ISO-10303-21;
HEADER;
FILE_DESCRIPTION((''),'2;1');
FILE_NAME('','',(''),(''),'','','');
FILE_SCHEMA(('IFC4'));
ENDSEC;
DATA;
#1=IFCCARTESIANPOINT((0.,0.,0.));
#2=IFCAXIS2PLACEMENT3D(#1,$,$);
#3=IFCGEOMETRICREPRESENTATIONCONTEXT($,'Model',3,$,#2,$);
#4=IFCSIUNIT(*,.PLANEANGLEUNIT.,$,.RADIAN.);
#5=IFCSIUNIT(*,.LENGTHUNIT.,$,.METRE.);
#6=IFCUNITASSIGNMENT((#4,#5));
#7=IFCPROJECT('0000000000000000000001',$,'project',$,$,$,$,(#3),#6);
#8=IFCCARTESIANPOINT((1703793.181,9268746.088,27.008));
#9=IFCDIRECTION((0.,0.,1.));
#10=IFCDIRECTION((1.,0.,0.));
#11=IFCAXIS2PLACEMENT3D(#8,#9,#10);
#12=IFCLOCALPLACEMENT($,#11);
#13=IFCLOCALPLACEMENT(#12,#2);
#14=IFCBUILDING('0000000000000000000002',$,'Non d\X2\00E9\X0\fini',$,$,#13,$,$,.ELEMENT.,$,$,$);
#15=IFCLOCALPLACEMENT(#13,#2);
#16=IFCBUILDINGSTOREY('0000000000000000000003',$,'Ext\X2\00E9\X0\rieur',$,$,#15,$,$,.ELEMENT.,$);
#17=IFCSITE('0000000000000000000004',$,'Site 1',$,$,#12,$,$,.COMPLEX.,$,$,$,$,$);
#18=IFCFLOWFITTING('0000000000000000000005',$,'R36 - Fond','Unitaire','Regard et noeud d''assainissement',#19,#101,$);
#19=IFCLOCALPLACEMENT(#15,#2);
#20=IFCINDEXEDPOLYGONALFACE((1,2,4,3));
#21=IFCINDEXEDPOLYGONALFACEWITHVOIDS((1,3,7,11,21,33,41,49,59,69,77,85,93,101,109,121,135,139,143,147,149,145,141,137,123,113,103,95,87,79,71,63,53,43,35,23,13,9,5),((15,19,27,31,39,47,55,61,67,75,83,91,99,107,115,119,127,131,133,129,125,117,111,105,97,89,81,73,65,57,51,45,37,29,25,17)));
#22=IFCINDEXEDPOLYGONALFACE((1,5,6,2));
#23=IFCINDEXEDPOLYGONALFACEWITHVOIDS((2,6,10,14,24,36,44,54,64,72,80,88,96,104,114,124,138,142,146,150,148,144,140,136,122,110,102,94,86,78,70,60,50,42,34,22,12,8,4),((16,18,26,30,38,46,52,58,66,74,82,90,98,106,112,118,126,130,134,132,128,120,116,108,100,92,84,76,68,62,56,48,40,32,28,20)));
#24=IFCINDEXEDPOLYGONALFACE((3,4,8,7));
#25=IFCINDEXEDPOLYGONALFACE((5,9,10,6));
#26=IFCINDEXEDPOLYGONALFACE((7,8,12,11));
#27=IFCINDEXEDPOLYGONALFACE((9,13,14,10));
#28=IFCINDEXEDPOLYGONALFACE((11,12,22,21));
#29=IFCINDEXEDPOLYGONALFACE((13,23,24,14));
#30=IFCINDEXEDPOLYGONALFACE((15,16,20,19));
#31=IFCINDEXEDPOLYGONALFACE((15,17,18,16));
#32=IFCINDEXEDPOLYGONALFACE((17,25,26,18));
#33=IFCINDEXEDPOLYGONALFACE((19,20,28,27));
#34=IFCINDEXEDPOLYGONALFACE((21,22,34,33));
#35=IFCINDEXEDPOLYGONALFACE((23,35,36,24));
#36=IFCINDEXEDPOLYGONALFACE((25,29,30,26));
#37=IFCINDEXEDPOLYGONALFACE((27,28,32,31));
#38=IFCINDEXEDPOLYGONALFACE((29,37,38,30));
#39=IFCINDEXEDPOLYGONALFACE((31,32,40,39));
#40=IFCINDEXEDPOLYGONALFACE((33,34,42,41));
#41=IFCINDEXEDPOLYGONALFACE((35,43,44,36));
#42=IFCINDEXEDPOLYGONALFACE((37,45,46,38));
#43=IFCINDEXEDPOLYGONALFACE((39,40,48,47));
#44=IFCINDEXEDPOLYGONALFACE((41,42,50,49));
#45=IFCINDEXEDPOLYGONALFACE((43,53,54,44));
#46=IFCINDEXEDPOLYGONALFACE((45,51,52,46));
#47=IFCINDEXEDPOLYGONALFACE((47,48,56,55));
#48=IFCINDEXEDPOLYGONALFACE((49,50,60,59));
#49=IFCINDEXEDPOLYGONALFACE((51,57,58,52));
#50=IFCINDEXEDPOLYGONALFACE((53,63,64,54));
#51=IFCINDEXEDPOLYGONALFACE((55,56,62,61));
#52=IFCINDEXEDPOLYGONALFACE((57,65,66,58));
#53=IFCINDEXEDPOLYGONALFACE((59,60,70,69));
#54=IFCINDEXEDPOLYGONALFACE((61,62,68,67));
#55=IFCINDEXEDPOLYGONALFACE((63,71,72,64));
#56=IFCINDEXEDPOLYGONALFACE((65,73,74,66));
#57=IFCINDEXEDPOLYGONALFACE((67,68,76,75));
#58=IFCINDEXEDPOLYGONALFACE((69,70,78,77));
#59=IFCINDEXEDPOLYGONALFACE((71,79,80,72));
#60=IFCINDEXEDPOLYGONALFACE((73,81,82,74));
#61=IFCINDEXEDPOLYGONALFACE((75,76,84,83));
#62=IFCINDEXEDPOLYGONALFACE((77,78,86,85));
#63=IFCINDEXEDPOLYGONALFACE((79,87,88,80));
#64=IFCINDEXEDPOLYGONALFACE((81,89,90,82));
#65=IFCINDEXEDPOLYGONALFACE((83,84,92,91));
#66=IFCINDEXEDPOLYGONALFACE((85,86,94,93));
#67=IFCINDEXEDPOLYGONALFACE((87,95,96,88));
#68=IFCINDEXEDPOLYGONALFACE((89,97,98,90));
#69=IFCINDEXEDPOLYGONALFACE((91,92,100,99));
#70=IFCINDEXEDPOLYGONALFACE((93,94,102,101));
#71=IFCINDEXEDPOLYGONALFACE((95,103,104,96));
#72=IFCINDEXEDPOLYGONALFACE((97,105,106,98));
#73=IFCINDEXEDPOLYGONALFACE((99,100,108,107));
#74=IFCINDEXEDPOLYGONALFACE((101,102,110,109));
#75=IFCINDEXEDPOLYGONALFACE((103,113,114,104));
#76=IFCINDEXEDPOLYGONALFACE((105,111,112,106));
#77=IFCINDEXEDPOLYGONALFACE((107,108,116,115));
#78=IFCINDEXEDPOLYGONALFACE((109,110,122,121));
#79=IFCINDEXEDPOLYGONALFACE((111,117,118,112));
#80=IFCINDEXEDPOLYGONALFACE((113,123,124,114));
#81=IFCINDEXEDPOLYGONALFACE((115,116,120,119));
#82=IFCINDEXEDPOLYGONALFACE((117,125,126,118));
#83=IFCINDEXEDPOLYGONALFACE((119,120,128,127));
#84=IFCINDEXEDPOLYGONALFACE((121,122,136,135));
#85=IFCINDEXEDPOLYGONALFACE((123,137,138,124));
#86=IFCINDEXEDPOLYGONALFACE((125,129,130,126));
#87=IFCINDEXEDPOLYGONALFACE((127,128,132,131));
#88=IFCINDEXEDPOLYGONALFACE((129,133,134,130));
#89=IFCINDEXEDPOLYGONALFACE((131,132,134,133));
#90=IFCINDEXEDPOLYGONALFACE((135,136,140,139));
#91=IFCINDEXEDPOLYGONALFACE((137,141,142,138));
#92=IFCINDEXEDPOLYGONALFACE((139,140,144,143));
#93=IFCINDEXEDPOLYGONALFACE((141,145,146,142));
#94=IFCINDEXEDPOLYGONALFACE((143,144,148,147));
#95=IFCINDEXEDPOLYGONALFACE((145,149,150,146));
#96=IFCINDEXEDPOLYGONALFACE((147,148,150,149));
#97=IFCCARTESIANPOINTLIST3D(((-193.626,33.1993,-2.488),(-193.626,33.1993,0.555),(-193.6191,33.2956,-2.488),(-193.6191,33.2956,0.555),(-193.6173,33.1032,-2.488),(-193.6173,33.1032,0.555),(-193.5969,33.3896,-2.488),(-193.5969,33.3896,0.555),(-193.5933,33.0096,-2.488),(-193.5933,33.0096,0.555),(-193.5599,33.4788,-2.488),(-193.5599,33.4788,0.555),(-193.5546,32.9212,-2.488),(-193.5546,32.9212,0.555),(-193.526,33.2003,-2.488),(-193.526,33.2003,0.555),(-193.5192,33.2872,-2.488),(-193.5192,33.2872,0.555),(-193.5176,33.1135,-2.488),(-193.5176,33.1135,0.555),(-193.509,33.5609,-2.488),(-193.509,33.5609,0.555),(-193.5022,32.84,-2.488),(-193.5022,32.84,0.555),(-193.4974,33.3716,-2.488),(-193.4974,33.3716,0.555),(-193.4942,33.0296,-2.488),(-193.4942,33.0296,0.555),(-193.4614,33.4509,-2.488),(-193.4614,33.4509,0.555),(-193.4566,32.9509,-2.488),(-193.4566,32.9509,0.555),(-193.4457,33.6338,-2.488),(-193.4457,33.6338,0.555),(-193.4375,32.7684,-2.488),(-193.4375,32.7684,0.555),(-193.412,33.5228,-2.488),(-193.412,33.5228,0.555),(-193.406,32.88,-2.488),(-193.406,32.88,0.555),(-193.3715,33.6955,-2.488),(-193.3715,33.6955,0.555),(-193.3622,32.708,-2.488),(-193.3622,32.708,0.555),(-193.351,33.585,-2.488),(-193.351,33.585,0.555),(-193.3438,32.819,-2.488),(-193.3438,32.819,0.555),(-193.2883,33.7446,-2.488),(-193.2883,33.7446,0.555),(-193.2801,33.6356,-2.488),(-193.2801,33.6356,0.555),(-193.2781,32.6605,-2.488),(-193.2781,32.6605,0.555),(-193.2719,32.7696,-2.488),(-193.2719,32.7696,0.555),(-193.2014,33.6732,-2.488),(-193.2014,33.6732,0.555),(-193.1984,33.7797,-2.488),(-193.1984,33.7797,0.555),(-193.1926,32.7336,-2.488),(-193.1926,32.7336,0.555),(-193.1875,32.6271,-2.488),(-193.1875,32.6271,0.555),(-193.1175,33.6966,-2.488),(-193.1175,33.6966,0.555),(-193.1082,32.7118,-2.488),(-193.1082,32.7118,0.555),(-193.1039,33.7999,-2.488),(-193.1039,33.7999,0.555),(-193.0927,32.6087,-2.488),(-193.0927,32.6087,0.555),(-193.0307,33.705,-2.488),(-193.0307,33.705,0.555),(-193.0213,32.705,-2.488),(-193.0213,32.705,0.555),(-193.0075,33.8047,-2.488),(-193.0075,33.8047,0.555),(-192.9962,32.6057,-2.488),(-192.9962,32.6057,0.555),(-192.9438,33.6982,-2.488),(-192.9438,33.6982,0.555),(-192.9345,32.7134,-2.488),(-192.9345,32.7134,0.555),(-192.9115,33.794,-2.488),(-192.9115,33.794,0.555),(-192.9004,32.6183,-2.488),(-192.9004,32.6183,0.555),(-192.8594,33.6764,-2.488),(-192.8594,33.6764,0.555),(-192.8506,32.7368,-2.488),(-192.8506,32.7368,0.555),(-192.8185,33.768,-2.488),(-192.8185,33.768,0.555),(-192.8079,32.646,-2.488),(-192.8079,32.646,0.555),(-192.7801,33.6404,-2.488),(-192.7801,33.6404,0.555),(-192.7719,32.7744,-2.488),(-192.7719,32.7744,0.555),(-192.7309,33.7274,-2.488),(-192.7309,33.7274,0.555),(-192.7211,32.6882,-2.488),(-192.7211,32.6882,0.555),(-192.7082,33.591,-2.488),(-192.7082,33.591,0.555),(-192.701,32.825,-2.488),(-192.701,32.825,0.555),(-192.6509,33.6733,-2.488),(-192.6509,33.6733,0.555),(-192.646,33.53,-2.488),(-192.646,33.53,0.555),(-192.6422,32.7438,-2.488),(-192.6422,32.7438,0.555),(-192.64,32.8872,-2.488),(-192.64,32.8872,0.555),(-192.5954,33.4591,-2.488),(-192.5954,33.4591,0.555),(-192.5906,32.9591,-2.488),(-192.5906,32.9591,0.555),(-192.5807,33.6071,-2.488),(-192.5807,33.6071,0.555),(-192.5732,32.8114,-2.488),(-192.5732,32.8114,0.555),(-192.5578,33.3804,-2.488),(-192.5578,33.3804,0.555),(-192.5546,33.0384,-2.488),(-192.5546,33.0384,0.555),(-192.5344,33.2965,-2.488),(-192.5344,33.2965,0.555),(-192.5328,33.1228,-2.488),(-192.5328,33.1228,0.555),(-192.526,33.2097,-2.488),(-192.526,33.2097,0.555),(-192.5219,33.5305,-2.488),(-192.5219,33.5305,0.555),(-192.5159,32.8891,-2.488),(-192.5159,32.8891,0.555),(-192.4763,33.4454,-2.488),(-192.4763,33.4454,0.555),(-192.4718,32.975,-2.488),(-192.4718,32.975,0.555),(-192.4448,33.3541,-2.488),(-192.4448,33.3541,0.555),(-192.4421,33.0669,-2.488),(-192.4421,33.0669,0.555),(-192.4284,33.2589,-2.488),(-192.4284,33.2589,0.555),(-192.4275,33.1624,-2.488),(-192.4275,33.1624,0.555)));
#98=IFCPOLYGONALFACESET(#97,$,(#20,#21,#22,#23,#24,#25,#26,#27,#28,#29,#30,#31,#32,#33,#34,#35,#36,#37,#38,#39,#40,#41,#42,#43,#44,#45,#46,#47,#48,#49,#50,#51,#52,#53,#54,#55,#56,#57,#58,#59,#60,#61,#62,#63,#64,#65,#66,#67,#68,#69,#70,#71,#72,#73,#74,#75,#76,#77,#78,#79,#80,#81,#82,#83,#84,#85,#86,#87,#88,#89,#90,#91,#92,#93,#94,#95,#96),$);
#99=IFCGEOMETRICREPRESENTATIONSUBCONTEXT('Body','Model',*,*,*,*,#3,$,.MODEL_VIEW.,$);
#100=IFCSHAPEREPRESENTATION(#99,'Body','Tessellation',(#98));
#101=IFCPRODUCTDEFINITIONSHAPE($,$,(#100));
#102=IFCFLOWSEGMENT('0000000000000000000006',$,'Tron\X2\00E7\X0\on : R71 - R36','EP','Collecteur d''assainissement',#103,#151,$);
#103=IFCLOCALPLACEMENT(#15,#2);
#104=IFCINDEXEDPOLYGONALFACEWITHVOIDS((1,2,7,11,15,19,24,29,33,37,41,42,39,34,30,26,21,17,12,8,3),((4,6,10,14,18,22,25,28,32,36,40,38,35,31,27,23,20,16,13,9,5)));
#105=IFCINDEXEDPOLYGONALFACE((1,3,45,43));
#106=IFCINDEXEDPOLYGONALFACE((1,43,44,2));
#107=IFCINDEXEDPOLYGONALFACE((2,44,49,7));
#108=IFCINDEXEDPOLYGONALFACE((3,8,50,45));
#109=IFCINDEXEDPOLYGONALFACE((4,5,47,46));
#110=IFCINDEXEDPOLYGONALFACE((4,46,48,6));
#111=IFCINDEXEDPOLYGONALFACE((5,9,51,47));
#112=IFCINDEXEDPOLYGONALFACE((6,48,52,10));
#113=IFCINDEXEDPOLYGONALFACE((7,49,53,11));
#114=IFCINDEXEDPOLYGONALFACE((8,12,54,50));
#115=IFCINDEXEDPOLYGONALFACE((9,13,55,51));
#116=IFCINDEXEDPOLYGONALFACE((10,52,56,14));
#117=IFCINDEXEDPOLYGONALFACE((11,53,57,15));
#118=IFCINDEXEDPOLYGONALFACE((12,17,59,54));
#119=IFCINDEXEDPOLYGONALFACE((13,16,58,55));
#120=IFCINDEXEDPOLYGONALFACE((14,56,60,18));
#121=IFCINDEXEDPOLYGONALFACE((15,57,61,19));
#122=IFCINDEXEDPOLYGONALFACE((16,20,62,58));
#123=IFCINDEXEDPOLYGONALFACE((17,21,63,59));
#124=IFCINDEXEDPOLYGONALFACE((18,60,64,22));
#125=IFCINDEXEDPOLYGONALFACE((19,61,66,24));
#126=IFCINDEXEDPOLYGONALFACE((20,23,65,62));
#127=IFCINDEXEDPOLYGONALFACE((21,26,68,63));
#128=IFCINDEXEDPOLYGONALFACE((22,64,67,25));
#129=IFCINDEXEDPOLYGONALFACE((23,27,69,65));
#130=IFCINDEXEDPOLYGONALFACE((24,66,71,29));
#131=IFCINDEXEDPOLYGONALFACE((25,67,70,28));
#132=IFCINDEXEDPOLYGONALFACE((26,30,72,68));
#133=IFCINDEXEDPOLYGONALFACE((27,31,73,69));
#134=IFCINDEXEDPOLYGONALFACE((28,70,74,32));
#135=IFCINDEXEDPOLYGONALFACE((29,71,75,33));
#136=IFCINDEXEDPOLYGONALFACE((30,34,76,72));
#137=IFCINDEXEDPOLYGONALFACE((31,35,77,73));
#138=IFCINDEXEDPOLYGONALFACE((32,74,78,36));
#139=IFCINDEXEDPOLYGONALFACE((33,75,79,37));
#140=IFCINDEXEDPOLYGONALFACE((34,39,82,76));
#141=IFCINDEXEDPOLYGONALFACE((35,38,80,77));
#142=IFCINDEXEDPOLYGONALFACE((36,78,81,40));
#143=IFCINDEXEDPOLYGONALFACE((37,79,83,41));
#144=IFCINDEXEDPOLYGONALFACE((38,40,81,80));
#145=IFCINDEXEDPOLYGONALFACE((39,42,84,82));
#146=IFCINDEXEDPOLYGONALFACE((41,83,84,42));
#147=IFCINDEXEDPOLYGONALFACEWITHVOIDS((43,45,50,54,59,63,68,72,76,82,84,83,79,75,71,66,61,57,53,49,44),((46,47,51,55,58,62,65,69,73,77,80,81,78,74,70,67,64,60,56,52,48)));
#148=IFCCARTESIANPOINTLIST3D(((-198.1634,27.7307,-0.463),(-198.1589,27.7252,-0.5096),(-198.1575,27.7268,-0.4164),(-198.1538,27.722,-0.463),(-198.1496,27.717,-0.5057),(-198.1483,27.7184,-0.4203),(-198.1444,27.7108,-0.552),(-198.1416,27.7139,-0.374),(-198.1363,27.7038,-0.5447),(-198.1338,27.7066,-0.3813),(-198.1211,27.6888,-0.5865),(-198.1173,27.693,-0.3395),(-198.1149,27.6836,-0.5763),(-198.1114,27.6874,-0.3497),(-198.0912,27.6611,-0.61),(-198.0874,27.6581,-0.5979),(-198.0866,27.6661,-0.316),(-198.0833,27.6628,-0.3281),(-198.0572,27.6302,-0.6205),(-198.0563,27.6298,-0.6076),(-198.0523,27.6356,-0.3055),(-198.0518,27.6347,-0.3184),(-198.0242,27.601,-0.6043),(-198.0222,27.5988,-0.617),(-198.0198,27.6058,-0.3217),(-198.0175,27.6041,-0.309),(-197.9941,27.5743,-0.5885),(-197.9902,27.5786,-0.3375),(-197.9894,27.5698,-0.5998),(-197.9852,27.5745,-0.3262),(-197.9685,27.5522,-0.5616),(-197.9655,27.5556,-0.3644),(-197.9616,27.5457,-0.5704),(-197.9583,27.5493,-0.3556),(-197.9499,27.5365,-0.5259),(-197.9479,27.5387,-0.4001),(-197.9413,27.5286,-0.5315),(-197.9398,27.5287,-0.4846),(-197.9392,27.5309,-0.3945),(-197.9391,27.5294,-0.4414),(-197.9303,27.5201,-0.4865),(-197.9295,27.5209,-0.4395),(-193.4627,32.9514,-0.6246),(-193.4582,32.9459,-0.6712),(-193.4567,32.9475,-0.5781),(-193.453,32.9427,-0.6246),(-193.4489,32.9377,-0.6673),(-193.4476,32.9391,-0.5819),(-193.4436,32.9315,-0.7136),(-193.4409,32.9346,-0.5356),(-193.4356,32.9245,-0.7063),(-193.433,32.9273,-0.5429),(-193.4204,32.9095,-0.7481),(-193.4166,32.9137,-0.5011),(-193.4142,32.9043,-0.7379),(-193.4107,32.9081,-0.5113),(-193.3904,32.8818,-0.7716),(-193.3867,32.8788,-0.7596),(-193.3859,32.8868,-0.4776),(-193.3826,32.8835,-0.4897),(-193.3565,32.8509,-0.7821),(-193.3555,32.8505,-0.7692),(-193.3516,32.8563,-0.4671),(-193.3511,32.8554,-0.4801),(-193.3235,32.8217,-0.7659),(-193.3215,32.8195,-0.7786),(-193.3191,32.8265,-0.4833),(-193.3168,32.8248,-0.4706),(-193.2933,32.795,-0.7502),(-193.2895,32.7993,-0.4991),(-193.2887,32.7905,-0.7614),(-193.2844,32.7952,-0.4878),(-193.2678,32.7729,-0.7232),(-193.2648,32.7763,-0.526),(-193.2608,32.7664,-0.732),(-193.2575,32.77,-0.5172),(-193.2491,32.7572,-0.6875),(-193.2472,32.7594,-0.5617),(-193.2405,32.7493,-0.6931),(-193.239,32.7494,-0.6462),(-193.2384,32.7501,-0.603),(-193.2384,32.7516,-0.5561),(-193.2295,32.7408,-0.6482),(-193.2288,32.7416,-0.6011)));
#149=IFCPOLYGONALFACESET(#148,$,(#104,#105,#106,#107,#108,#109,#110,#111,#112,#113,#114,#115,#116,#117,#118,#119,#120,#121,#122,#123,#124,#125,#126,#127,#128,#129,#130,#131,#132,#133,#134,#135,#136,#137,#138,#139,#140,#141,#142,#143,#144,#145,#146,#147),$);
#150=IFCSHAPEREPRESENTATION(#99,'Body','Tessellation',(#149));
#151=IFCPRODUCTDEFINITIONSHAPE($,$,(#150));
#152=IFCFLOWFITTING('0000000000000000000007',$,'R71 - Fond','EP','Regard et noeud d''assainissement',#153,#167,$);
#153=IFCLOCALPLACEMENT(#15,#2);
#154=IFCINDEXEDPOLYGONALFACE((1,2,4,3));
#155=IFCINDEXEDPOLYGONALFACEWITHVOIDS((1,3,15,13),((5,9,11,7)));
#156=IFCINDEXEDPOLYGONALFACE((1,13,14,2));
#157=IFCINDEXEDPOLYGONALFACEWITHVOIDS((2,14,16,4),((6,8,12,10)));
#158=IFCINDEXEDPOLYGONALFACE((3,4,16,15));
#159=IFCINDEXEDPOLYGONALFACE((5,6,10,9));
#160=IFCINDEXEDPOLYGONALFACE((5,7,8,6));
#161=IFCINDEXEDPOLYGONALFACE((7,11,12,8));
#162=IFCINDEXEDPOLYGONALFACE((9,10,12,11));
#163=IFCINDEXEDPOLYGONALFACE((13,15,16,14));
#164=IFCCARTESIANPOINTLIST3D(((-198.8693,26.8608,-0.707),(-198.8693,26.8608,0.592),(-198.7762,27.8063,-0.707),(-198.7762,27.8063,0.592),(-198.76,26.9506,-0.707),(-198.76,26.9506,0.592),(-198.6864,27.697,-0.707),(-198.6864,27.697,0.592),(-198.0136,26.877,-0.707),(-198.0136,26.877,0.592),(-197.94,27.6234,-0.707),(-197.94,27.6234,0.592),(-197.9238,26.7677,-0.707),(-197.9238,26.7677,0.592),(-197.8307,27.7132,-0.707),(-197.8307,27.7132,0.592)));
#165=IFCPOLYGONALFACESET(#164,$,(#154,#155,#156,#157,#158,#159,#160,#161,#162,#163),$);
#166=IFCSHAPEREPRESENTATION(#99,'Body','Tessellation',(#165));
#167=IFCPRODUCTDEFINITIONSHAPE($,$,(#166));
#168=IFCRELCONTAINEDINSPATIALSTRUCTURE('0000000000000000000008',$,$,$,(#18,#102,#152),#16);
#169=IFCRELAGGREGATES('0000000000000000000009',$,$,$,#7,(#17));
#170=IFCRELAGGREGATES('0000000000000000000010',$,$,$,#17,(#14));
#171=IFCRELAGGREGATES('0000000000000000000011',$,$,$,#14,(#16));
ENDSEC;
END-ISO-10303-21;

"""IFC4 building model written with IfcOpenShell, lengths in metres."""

from ifc_helpers import new_model, si_unit, frame, origin, origin_2d, place, context, subcontext, project, spatial, hollow_rectangle, hollow_circle, extrude, element, save


model = new_model("IFC4")

# Units and contexts
model_context = context("Model", 3, world=origin())
body_context = subcontext(model_context, "Body", "Model", "MODEL_VIEW")
ifc_project = project(units=[si_unit("PLANEANGLEUNIT", "RADIAN"), si_unit("LENGTHUNIT", "METRE")], contexts=[model_context])

# Site, building, storey
site_placement = place(None, frame((1703793.181, 9268746.088, 27.008), z_axis=(0.0, 0.0, 1.0), x_axis=(1.0, 0.0, 0.0)))
site = spatial("IfcSite", under=ifc_project, at=site_placement, Name="Site 1", CompositionType="COMPLEX")
building_placement = place(site_placement, origin())
building = spatial("IfcBuilding", under=site, at=building_placement, Name="Non défini", CompositionType="ELEMENT")
storey_placement = place(building_placement, origin())
storey = spatial("IfcBuildingStorey", under=building, at=storey_placement, Name="Extérieur", CompositionType="ELEMENT")

# Flow fitting
flow_fitting_1_placement = place(storey_placement, origin())
element("IfcFlowFitting", 1, at=flow_fitting_1_placement, inside=storey, Name="R36 - Fond", Description="Unitaire", ObjectType="Regard et noeud d'assainissement", context=body_context, shape_type="SweptSolid", body=[
    extrude(hollow_circle(Radius=0.6, WallThickness=0.1, at=origin_2d()), frame((-193.026, 33.205, -2.488), z_axis=(0.0, 0.0, 1.0), x_axis=(0.508, -0.861, 0.0)), (0.0, 0.0, 1.0), 3.043),
])

# Flow segment
flow_segment_1_placement = place(storey_placement, origin())
element("IfcFlowSegment", 2, at=flow_segment_1_placement, inside=storey, Name="Tronçon : R71 - R36", Description="EP", ObjectType="Collecteur d'assainissement", context=body_context, shape_type="SweptSolid", body=[
    extrude(hollow_circle(Radius=0.158, WallThickness=0.013, at=origin_2d()), frame((-198.046, 27.625, -0.463), z_axis=(0.669, 0.743, -0.023), x_axis=(-0.743, 0.669, 0.0)), (0.0, 0.0, 1.0), 7.027),
])

# Flow fitting
flow_fitting_2_placement = place(storey_placement, origin())
element("IfcFlowFitting", 3, at=flow_fitting_2_placement, inside=storey, Name="R71 - Fond", Description="EP", ObjectType="Regard et noeud d'assainissement", context=body_context, shape_type="SweptSolid", body=[
    extrude(hollow_rectangle(XDim=0.95, YDim=0.95, WallThickness=0.1, at=origin_2d()), frame((-198.35, 27.287, -0.707), z_axis=(0.0, 0.0, 1.0), x_axis=(0.098, 0.995, 0.0)), (0.0, 0.0, 1.0), 1.299),
])

save(model, "model.ifc")
